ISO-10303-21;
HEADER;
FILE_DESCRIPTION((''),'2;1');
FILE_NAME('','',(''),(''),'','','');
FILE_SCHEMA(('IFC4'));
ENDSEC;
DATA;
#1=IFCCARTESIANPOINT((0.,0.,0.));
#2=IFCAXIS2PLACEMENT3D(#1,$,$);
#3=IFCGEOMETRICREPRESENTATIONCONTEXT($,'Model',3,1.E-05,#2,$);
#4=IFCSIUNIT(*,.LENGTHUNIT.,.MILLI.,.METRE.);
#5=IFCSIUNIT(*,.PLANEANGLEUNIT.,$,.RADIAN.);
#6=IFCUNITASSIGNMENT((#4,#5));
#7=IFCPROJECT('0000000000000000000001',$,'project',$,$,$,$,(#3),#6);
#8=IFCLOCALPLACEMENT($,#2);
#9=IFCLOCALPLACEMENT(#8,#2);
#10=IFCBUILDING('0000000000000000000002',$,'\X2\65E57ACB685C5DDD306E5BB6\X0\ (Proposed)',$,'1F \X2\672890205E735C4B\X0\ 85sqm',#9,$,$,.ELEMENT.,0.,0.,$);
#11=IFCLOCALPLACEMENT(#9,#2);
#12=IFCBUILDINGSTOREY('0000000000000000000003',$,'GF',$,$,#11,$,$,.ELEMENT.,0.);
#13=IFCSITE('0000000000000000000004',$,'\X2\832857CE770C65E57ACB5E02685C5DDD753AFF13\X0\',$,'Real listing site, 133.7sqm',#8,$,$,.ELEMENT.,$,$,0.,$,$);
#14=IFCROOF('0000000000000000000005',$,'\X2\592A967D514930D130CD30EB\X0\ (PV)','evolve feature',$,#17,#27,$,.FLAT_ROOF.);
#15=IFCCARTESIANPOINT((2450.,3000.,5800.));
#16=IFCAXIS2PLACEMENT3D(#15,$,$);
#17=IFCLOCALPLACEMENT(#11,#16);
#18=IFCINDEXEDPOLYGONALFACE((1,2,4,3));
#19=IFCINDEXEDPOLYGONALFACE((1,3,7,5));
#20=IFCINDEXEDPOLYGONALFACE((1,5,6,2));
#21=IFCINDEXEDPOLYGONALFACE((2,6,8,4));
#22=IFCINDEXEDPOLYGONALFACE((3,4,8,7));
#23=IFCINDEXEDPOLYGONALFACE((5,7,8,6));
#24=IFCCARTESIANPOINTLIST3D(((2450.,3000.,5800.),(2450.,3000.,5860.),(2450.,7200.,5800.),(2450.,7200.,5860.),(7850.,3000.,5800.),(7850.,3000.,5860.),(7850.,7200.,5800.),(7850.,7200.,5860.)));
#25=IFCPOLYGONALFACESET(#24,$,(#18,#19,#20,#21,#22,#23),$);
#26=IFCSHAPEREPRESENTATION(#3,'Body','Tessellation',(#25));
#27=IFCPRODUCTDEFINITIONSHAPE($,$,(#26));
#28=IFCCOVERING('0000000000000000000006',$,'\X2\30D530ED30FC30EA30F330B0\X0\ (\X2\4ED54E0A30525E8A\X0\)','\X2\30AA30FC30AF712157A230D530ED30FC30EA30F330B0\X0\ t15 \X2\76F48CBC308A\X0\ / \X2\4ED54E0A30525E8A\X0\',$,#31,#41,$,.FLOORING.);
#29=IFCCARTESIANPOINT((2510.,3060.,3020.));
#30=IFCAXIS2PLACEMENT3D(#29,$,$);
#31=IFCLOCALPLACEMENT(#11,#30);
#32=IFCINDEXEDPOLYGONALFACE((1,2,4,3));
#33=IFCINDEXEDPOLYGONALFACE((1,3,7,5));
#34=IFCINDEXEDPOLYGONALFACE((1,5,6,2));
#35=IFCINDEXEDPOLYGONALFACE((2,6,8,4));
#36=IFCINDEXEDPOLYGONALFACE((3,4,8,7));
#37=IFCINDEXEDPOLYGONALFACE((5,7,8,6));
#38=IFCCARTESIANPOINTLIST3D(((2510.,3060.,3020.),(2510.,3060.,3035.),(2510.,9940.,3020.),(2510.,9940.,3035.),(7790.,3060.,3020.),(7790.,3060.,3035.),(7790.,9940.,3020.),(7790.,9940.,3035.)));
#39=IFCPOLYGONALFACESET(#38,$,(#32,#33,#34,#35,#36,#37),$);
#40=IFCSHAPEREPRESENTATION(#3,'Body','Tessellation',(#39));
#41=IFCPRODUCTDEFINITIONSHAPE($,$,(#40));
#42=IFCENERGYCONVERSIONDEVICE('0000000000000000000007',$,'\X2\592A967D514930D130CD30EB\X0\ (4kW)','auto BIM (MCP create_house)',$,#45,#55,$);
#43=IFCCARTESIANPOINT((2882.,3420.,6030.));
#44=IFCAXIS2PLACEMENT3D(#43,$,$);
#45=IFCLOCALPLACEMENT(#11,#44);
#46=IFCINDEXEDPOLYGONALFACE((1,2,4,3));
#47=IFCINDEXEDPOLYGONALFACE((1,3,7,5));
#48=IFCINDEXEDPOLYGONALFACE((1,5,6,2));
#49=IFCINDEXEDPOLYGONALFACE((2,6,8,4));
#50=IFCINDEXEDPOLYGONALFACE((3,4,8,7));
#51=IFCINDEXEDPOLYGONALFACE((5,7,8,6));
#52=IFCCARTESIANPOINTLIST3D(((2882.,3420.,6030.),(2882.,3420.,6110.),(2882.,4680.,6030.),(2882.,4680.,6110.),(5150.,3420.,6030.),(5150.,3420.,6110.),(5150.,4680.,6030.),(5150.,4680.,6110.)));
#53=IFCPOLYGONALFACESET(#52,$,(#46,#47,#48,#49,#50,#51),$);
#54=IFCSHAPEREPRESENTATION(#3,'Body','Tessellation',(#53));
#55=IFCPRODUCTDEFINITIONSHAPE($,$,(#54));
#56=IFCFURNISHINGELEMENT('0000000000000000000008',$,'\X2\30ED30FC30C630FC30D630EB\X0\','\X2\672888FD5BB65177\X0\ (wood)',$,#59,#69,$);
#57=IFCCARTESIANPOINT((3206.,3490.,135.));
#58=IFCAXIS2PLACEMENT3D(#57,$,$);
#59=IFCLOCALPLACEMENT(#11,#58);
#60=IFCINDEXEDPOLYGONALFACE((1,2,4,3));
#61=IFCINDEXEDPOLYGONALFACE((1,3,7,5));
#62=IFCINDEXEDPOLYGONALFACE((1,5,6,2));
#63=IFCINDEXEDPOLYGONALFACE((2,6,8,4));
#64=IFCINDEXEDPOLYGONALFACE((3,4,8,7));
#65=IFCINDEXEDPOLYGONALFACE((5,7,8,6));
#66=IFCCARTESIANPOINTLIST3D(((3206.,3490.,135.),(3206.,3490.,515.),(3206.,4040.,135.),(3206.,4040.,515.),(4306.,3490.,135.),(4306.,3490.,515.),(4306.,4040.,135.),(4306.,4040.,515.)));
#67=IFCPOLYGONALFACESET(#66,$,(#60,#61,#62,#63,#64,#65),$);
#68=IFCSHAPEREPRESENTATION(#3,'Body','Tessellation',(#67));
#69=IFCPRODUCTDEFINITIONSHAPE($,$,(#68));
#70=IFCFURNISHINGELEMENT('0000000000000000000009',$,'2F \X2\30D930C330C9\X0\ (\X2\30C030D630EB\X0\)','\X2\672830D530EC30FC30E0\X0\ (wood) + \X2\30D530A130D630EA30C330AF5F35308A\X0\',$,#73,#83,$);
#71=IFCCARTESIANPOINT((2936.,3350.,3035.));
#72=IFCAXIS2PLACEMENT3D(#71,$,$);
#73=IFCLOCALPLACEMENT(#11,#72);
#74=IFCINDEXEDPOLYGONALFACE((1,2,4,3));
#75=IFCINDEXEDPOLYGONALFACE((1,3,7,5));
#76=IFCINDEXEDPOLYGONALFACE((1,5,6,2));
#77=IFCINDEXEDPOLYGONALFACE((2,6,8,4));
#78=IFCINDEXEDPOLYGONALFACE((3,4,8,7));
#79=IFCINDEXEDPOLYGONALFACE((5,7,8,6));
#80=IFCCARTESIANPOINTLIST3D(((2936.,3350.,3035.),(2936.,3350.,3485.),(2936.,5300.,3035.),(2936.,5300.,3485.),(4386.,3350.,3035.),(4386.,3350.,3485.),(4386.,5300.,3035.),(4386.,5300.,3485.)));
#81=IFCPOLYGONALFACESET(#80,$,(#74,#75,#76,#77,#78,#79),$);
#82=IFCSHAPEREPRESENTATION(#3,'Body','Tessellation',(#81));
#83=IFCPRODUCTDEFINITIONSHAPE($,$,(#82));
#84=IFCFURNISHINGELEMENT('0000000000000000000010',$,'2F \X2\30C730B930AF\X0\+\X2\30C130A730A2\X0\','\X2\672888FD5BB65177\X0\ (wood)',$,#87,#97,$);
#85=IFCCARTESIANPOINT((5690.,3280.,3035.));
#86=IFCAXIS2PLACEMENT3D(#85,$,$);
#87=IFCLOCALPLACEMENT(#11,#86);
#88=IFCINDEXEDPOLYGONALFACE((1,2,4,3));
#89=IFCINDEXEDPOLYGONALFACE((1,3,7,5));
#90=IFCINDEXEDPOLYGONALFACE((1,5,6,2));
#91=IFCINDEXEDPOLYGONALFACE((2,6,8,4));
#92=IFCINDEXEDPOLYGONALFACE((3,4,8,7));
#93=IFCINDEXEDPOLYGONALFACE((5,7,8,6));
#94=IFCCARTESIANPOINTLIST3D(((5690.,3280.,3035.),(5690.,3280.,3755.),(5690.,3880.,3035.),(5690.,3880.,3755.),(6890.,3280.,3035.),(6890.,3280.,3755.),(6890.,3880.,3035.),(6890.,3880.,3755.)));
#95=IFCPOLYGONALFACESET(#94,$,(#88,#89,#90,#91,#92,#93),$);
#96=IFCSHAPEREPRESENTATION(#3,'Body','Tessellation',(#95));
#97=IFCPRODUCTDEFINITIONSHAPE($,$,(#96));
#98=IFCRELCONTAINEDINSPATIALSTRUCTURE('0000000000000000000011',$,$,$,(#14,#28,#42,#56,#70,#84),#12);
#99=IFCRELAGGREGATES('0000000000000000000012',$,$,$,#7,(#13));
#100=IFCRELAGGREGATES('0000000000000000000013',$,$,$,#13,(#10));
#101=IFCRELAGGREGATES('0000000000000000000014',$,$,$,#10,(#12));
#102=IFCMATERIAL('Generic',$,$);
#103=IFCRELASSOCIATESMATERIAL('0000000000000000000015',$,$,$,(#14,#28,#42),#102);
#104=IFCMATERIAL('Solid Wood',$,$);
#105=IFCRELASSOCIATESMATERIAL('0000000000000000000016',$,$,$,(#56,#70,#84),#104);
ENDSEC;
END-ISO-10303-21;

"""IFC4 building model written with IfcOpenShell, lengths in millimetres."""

from ifc_helpers import new_model, si_unit, frame, frame_2d, origin, place, context, project, spatial, rectangle, extrude, material, element, save


model = new_model("IFC4")

# Units and contexts
model_context = context("Model", 3, precision=1e-05, world=origin())
ifc_project = project(units=[si_unit("LENGTHUNIT", "METRE", prefix="MILLI"), si_unit("PLANEANGLEUNIT", "RADIAN")], contexts=[model_context])

# Site, building, storey
site_placement = place(None, origin())
site = spatial("IfcSite", under=ifc_project, at=site_placement, Name="茨城県日立市桜川町３", ObjectType="Real listing site, 133.7sqm", CompositionType="ELEMENT", RefElevation=0.0)
building_placement = place(site_placement, origin())
building = spatial("IfcBuilding", under=site, at=building_placement, Name="日立桜川の家 (Proposed)", ObjectType="1F 木造平屋 85sqm", CompositionType="ELEMENT", ElevationOfRefHeight=0.0, ElevationOfTerrain=0.0)
storey_placement = place(building_placement, origin())
storey = spatial("IfcBuildingStorey", under=building, at=storey_placement, Name="GF", CompositionType="ELEMENT", Elevation=0.0)

# Shared definitions
ifc_material_1 = material(Name="Solid Wood")

# Shared definitions
ifc_material_2 = material(Name="Generic")

# Roof
roof_1_placement = place(storey_placement, frame((2450.0, 3000.0, 5800.0)))
element("IfcRoof", 1, at=roof_1_placement, inside=storey, material=ifc_material_2, Name="太陽光パネル (PV)", Description="evolve feature", PredefinedType="FLAT_ROOF", context=model_context, shape_type="SweptSolid", body=[
    extrude(rectangle(XDim=5400.0, YDim=4200.0, at=frame_2d((2700.0, 2100.0))), frame((2450.0, 3000.0, 5800.0)), (0.0, 0.0, 1.0), 60.0),
])

# Covering
covering_placement = place(storey_placement, frame((2510.0, 3060.0, 3020.0)))
element("IfcCovering", 2, at=covering_placement, inside=storey, material=ifc_material_2, Name="フローリング (仕上げ床)", Description="オーク無垢フローリング t15 直貼り / 仕上げ床", PredefinedType="FLOORING", context=model_context, shape_type="SweptSolid", body=[
    extrude(rectangle(XDim=5280.0, YDim=6880.0, at=frame_2d((2640.0, 3440.0))), frame((2510.0, 3060.0, 3020.0)), (0.0, 0.0, 1.0), 15.0),
])

# Energy conversion device
energy_conversion_device_placement = place(storey_placement, frame((2882.0, 3420.0, 6030.0)))
element("IfcEnergyConversionDevice", 3, at=energy_conversion_device_placement, inside=storey, material=ifc_material_2, Name="太陽光パネル (4kW)", Description="auto BIM (MCP create_house)", context=model_context, shape_type="SweptSolid", body=[
    extrude(rectangle(XDim=2268.0, YDim=1260.0, at=frame_2d((1134.0, 630.0))), frame((2882.0, 3420.0, 6030.0)), (0.0, 0.0, 1.0), 80.0),
])

# Furnishing elements
furnishing_1_placement = place(storey_placement, frame((3206.0, 3490.0, 135.0)))
element("IfcFurnishingElement", 4, at=furnishing_1_placement, inside=storey, material=ifc_material_1, Name="ローテーブル", Description="木製家具 (wood)", context=model_context, shape_type="SweptSolid", body=[
    extrude(rectangle(XDim=1100.0, YDim=550.0, at=frame_2d((550.0, 275.0))), frame((3206.0, 3490.0, 135.0)), (0.0, 0.0, 1.0), 380.0),
])
furnishing_2_placement = place(storey_placement, frame((2936.0, 3350.0, 3035.0)))
element("IfcFurnishingElement", 5, at=furnishing_2_placement, inside=storey, material=ifc_material_1, Name="2F ベッド (ダブル)", Description="木フレーム (wood) + ファブリック張り", context=model_context, shape_type="SweptSolid", body=[
    extrude(rectangle(XDim=1450.0, YDim=1950.0, at=frame_2d((725.0, 975.0))), frame((2936.0, 3350.0, 3035.0)), (0.0, 0.0, 1.0), 450.0),
])
furnishing_3_placement = place(storey_placement, frame((5690.0, 3280.0, 3035.0)))
element("IfcFurnishingElement", 6, at=furnishing_3_placement, inside=storey, material=ifc_material_1, Name="2F デスク+チェア", Description="木製家具 (wood)", context=model_context, shape_type="SweptSolid", body=[
    extrude(rectangle(XDim=1200.0, YDim=600.0, at=frame_2d((600.0, 300.0))), frame((5690.0, 3280.0, 3035.0)), (0.0, 0.0, 1.0), 720.0),
])

save(model, "model.ifc")
